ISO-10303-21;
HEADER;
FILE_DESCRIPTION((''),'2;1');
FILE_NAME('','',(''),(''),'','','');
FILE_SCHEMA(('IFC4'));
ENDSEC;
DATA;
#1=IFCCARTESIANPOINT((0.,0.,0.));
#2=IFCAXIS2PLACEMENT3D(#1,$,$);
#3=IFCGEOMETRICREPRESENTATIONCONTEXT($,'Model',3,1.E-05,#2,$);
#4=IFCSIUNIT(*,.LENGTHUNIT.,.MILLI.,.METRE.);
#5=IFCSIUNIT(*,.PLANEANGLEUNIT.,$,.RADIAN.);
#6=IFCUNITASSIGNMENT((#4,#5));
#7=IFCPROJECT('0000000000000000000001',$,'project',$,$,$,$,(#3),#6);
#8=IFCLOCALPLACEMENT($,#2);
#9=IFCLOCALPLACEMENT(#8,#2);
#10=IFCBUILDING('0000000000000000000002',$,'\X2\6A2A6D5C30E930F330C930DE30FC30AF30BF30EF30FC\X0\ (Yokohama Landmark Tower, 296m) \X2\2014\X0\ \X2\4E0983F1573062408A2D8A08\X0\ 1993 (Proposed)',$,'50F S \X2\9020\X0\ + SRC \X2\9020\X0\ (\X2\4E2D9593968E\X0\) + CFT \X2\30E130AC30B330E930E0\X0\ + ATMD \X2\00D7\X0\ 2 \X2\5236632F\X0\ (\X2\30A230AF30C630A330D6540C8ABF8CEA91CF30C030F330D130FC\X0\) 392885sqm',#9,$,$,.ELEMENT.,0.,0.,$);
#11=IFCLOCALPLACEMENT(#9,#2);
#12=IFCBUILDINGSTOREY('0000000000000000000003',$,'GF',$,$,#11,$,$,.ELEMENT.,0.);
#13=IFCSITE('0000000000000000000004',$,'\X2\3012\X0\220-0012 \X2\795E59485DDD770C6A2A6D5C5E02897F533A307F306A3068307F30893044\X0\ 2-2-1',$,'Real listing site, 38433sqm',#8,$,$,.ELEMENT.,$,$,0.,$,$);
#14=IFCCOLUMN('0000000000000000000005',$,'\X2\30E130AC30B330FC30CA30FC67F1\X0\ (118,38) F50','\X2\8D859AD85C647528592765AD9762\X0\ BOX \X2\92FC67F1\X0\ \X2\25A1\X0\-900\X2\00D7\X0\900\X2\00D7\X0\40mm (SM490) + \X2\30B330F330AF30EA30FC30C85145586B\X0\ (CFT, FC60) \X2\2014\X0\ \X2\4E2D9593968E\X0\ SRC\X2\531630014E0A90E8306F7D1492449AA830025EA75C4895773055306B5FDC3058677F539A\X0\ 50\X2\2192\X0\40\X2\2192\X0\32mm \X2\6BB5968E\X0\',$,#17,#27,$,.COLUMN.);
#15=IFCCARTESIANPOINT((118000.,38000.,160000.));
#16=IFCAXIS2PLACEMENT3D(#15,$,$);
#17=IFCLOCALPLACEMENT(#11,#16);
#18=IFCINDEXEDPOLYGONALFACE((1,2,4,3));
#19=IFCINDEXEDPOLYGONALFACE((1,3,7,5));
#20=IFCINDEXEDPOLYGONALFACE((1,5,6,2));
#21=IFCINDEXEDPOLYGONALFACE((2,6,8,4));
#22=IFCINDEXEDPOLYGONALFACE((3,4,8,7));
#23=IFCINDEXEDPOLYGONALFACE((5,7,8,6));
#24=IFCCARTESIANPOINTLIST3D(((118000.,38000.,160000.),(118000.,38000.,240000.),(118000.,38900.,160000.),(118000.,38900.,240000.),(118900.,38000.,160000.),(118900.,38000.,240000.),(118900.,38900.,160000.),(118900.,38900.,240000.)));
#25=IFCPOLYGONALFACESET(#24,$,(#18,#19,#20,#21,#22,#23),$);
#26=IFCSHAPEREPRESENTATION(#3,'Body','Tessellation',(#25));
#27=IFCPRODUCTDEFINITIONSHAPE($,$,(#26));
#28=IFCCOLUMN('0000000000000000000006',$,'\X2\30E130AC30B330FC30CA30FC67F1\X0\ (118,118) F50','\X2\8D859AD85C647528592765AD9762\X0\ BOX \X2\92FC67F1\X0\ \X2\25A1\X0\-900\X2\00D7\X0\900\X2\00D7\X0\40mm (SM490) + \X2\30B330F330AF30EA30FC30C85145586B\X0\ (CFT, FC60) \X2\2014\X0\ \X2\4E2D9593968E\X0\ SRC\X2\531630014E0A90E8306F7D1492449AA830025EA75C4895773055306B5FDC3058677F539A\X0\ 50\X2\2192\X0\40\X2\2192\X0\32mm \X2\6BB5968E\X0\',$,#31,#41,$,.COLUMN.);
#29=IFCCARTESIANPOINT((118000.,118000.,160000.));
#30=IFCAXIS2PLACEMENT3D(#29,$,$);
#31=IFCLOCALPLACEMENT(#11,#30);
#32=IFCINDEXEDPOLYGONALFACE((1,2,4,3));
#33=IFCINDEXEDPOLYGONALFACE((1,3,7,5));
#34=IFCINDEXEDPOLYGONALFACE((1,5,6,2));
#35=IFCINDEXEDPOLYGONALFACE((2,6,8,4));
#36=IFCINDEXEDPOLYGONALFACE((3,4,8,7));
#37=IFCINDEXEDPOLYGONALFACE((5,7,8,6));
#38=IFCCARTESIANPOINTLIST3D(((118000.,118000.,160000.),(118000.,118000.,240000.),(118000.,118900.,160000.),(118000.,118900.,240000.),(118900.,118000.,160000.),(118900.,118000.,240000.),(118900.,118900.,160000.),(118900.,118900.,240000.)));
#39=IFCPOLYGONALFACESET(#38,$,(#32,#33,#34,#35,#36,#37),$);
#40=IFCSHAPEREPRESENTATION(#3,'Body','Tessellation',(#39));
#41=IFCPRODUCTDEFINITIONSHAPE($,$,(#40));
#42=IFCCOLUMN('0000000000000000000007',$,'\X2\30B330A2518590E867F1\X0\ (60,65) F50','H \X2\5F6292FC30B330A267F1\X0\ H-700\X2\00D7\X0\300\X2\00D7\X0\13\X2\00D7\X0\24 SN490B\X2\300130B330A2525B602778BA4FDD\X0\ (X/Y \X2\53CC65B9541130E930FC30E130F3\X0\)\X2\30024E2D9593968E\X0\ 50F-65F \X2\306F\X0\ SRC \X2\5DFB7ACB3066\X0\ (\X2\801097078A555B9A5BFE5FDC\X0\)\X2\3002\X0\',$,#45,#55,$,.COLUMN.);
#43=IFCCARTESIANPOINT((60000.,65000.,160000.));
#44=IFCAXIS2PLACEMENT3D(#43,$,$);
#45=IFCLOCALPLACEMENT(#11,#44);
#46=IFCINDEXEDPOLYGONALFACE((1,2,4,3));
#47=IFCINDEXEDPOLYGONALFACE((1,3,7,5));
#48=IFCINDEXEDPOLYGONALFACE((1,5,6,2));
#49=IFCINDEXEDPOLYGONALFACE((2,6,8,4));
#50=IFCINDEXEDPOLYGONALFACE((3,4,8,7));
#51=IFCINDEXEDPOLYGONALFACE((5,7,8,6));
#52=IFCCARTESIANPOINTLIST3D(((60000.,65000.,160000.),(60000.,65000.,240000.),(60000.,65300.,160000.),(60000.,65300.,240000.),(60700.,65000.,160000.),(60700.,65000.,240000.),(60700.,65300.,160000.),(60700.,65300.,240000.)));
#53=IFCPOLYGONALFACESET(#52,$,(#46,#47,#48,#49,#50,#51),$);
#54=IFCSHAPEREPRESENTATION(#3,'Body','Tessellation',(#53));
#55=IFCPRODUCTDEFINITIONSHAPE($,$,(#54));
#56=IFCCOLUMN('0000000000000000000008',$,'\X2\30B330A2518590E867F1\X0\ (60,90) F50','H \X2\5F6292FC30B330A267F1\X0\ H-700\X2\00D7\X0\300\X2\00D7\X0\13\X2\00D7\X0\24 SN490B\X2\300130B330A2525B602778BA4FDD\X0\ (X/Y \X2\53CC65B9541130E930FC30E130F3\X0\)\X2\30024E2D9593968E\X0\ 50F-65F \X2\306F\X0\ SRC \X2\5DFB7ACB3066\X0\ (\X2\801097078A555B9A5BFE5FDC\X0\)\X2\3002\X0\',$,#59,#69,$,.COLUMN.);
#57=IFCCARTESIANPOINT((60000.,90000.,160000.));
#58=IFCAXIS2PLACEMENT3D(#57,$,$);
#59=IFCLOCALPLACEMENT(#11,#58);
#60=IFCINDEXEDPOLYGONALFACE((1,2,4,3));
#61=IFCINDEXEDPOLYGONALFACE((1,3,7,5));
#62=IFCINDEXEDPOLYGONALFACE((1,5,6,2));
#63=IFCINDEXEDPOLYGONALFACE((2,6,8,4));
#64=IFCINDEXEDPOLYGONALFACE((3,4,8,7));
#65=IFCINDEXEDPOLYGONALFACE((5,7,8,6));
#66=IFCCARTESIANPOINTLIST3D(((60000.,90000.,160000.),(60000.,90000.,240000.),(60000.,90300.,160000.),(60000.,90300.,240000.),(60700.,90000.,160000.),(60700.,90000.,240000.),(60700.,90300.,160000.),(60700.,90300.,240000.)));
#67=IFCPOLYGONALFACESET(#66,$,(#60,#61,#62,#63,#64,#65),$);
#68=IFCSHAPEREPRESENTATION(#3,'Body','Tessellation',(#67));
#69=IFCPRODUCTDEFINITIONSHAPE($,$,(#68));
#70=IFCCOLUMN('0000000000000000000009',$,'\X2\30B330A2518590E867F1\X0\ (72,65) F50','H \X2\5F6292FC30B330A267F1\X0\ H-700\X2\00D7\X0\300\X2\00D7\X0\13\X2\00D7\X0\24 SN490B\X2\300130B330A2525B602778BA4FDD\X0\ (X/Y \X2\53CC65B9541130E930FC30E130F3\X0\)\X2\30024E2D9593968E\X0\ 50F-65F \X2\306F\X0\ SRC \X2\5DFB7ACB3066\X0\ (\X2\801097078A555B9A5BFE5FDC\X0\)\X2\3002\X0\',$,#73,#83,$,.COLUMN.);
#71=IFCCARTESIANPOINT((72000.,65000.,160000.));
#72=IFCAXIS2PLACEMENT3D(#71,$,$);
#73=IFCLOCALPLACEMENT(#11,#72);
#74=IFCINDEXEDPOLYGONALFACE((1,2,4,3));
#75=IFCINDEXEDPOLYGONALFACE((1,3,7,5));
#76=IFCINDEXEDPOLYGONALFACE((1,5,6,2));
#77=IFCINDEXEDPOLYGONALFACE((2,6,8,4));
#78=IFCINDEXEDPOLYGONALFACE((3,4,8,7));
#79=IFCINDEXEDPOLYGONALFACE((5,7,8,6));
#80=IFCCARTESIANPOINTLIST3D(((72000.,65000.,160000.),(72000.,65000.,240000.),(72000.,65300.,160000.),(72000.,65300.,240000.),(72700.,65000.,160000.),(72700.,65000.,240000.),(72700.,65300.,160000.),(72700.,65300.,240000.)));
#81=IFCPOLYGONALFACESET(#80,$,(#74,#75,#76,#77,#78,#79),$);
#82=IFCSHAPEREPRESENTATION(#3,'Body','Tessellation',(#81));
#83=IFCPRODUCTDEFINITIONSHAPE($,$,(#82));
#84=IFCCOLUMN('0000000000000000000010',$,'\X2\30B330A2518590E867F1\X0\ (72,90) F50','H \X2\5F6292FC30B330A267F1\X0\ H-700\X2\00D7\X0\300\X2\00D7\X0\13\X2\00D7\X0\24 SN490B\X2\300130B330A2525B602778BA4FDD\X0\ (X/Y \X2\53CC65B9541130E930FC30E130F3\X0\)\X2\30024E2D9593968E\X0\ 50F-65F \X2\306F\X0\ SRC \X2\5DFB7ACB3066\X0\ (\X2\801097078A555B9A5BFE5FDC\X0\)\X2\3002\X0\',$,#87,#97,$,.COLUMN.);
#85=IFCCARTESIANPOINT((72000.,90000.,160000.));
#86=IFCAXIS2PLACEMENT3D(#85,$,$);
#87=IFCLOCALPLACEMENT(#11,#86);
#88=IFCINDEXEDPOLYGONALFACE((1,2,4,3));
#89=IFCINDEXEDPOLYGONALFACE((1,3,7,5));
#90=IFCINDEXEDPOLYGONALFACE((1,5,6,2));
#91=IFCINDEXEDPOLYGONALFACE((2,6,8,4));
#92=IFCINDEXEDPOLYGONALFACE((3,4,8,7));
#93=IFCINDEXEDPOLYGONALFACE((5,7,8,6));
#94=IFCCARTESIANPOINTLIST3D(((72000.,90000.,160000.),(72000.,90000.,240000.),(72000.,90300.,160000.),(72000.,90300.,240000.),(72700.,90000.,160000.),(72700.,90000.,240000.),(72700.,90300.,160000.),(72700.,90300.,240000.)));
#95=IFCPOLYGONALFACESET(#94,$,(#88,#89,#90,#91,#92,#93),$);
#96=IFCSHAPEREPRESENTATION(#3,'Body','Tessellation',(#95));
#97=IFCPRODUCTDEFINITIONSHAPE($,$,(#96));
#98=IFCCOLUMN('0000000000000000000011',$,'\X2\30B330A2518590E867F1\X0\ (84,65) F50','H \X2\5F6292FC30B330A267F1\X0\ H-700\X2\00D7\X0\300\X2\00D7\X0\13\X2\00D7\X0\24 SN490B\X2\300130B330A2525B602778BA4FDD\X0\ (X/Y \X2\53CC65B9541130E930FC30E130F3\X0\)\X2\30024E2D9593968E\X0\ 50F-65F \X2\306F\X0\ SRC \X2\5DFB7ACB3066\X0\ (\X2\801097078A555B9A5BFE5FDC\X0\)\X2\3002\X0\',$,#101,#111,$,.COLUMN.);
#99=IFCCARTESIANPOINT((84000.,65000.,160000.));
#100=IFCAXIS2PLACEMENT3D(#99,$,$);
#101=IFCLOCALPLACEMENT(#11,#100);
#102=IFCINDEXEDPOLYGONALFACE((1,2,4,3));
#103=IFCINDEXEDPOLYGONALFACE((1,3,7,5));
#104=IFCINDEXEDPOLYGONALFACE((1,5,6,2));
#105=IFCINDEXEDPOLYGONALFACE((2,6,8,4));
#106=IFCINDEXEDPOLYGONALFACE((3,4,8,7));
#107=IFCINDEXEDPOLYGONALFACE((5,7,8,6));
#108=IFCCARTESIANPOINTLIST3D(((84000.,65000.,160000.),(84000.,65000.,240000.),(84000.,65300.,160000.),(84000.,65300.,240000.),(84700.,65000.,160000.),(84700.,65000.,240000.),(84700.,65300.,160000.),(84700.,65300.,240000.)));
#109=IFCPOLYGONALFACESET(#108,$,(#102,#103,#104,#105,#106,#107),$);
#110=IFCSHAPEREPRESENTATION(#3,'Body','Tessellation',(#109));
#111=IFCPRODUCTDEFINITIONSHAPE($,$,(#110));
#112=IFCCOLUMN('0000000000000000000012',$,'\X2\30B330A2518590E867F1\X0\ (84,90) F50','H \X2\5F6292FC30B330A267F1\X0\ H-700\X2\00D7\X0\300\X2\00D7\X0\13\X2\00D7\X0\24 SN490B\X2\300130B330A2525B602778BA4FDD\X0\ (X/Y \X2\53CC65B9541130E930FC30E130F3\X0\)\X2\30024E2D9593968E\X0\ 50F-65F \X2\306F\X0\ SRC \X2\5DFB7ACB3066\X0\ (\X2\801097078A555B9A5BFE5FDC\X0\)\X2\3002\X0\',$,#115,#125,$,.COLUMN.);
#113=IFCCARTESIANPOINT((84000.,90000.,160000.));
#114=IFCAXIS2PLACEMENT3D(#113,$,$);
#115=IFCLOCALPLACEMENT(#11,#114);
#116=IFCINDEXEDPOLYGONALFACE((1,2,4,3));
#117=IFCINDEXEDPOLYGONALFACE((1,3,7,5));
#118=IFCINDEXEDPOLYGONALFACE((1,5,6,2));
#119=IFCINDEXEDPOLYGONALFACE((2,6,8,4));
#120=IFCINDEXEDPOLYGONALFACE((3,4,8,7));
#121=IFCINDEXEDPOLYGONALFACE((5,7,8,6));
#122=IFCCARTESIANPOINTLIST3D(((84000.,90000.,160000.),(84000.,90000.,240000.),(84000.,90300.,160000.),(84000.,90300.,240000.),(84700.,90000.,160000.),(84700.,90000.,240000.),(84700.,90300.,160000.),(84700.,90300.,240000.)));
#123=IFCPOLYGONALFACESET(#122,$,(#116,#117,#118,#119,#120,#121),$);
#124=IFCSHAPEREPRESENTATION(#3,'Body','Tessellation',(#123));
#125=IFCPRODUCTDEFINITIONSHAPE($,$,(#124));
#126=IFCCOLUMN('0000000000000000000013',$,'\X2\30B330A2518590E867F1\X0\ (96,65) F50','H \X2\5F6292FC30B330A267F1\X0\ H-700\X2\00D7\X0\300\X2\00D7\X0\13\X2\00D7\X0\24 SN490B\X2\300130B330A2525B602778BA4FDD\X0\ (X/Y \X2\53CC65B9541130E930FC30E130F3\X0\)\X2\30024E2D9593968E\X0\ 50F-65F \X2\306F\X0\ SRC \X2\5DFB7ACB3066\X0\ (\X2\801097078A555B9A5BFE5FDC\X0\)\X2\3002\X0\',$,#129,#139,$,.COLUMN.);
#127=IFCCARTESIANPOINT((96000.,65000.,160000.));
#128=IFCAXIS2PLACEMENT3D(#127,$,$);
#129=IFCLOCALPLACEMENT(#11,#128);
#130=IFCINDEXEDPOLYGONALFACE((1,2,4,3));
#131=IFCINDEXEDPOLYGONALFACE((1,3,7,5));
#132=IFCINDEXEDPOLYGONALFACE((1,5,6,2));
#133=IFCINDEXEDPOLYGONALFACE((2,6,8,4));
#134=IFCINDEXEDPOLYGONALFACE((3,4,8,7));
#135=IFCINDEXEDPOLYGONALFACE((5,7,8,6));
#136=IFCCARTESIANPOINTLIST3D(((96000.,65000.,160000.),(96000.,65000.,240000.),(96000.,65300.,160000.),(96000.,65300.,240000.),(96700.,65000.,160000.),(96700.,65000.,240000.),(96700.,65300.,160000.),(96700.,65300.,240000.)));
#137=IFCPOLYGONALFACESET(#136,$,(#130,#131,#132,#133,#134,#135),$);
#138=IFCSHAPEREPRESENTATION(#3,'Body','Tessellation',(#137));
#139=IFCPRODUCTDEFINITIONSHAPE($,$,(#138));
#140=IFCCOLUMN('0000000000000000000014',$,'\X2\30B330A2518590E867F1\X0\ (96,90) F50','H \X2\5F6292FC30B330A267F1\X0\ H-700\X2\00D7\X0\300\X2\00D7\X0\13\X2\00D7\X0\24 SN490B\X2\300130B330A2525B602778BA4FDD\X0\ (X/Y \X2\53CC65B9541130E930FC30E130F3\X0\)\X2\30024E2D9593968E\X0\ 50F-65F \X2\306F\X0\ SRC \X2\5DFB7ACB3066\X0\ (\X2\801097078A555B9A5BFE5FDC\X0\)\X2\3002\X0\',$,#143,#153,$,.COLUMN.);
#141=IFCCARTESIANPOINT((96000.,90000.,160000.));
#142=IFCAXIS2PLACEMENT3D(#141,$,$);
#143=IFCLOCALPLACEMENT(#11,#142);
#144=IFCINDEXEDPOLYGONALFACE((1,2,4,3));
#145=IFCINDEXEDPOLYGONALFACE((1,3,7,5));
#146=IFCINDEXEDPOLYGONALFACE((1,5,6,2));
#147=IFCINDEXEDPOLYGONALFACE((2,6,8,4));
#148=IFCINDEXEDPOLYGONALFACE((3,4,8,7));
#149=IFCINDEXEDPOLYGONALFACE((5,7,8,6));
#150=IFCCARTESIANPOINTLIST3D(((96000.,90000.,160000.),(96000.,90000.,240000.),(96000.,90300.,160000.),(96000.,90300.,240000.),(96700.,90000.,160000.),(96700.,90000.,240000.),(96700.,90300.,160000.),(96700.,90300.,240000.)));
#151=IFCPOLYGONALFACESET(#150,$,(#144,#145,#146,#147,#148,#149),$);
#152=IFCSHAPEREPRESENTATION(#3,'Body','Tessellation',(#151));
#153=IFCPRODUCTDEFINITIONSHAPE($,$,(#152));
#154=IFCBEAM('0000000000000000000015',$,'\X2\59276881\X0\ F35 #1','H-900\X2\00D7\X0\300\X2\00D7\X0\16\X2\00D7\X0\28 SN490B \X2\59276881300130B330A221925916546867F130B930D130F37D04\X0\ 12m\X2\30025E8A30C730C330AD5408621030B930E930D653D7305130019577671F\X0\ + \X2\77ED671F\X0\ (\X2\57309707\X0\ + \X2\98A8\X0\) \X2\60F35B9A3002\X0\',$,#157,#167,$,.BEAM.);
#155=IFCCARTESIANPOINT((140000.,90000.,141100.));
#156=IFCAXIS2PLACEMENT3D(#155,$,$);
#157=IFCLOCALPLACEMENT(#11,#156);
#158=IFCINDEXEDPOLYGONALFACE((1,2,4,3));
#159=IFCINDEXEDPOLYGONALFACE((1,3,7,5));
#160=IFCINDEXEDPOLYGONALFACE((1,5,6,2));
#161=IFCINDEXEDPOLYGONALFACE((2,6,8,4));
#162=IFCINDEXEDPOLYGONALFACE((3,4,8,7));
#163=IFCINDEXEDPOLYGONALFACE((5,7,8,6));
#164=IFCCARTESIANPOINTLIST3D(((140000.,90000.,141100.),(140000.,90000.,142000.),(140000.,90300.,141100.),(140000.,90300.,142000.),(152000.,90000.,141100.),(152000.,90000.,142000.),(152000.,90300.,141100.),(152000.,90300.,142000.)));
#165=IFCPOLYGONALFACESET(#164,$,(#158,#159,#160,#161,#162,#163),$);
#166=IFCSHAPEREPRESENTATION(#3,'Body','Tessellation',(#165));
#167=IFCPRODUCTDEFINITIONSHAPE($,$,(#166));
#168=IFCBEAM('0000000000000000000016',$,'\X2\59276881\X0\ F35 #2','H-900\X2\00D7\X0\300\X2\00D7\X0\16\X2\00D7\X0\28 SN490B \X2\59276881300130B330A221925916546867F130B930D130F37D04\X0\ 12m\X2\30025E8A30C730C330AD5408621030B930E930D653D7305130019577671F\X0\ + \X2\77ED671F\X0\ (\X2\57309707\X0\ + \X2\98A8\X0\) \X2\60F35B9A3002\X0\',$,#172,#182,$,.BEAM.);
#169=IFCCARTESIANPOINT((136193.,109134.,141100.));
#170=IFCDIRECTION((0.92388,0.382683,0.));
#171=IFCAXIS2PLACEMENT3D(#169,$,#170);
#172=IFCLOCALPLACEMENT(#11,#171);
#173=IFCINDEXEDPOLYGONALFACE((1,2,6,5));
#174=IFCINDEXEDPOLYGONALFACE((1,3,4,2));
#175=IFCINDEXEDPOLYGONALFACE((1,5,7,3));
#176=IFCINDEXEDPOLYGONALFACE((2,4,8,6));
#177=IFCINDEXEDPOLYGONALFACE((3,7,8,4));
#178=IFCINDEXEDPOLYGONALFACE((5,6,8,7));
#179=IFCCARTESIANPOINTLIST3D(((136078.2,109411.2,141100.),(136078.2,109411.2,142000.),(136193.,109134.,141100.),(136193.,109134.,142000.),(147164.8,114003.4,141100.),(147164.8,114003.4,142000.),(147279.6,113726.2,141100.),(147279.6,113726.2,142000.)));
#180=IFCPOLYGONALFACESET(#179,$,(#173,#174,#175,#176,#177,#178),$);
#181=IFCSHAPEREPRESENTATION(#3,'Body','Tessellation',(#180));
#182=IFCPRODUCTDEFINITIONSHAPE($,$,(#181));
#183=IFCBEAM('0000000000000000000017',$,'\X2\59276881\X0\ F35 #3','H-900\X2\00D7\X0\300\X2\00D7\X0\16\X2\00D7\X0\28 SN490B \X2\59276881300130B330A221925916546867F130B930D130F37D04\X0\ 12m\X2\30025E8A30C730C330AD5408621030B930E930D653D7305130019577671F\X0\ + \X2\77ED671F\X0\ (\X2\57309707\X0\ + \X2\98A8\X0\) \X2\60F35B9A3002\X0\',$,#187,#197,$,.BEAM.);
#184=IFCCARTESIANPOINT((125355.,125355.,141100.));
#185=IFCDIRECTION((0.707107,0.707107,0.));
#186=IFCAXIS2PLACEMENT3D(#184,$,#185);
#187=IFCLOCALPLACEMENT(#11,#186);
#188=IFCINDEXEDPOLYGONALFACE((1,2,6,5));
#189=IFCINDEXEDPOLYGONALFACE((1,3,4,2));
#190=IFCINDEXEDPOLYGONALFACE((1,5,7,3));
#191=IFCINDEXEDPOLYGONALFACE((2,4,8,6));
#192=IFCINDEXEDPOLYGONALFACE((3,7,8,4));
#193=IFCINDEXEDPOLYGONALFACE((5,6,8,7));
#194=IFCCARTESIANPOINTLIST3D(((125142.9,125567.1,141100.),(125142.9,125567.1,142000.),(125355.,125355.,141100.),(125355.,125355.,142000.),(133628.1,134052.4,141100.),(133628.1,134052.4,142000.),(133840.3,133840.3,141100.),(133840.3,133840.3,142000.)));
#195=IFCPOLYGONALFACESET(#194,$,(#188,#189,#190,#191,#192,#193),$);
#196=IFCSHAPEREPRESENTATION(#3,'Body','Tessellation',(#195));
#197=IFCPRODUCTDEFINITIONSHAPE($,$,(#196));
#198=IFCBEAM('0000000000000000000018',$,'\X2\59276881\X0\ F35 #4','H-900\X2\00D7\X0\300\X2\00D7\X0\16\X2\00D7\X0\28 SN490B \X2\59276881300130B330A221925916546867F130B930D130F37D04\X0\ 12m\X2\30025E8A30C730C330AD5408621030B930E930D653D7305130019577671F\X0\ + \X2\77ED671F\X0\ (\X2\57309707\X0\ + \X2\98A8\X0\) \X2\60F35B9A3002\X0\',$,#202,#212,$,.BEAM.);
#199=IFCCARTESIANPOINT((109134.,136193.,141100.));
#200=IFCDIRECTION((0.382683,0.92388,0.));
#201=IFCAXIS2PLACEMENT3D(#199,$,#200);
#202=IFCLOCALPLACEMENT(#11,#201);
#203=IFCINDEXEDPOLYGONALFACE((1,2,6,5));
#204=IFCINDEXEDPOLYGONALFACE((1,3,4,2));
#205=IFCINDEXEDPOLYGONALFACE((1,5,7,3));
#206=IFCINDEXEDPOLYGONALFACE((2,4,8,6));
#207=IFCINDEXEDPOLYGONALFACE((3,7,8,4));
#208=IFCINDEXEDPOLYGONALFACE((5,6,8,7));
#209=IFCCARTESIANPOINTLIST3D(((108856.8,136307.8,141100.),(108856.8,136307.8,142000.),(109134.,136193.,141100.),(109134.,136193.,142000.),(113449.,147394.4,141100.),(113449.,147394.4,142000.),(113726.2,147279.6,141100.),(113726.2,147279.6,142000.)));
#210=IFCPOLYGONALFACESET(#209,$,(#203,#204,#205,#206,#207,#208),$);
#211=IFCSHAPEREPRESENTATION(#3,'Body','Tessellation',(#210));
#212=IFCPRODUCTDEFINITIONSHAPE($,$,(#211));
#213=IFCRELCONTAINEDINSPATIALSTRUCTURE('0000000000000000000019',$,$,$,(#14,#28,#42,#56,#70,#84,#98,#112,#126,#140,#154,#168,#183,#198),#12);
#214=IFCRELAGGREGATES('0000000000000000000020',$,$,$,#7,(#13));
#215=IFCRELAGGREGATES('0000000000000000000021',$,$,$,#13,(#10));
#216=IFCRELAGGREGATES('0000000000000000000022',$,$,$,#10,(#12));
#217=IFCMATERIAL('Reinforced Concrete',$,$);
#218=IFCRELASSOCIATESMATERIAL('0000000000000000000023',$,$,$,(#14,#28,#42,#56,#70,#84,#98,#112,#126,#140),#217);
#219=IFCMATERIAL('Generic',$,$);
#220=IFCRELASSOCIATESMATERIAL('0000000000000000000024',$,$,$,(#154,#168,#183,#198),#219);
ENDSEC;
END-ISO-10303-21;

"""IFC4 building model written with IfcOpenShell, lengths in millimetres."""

from ifc_helpers import new_model, si_unit, frame, frame_2d, origin, place, context, project, spatial, rectangle, extrude, material, element, save


model = new_model("IFC4")

# Units and contexts
model_context = context("Model", 3, precision=1e-05, world=origin())
ifc_project = project(units=[si_unit("LENGTHUNIT", "METRE", prefix="MILLI"), si_unit("PLANEANGLEUNIT", "RADIAN")], contexts=[model_context])

# Site, building, storey
site_placement = place(None, origin())
site = spatial("IfcSite", under=ifc_project, at=site_placement, Name="〒220-0012 神奈川県横浜市西区みなとみらい 2-2-1", ObjectType="Real listing site, 38433sqm", CompositionType="ELEMENT", RefElevation=0.0)
building_placement = place(site_placement, origin())
building = spatial("IfcBuilding", under=site, at=building_placement, Name="横浜ランドマークタワー (Yokohama Landmark Tower, 296m) — 三菱地所設計 1993 (Proposed)", ObjectType="50F S 造 + SRC 造 (中間階) + CFT メガコラム + ATMD × 2 制振 (アクティブ同調質量ダンパー) 392885sqm", CompositionType="ELEMENT", ElevationOfRefHeight=0.0, ElevationOfTerrain=0.0)
storey_placement = place(building_placement, origin())
storey = spatial("IfcBuildingStorey", under=building, at=storey_placement, Name="GF", CompositionType="ELEMENT", Elevation=0.0)

# Columns
ifc_material_1 = material(Name="Reinforced Concrete")
column_1_placement = place(storey_placement, frame((118000.0, 38000.0, 160000.0)))
element("IfcColumn", 1, at=column_1_placement, inside=storey, material=ifc_material_1, Name="メガコーナー柱 (118,38) F50", Description="超高層用大断面 BOX 鋼柱 □-900×900×40mm (SM490) + コンクリート充填 (CFT, FC60) — 中間階 SRC化、上部は純鉄骨。座屈長さに応じ板厚 50→40→32mm 段階", PredefinedType="COLUMN", context=model_context, shape_type="SweptSolid", body=[
    extrude(rectangle(XDim=900.0, YDim=900.0, at=frame_2d((450.0, 450.0))), frame((118000.0, 38000.0, 160000.0)), (0.0, 0.0, 1.0), 80000.0),
])
column_2_placement = place(storey_placement, frame((118000.0, 118000.0, 160000.0)))
element("IfcColumn", 2, at=column_2_placement, inside=storey, material=ifc_material_1, Name="メガコーナー柱 (118,118) F50", Description="超高層用大断面 BOX 鋼柱 □-900×900×40mm (SM490) + コンクリート充填 (CFT, FC60) — 中間階 SRC化、上部は純鉄骨。座屈長さに応じ板厚 50→40→32mm 段階", PredefinedType="COLUMN", context=model_context, shape_type="SweptSolid", body=[
    extrude(rectangle(XDim=900.0, YDim=900.0, at=frame_2d((450.0, 450.0))), frame((118000.0, 118000.0, 160000.0)), (0.0, 0.0, 1.0), 80000.0),
])
column_3_placement = place(storey_placement, frame((60000.0, 65000.0, 160000.0)))
element("IfcColumn", 3, at=column_3_placement, inside=storey, material=ifc_material_1, Name="コア内部柱 (60,65) F50", Description="H 形鋼コア柱 H-700×300×13×24 SN490B、コア剛性確保 (X/Y 双方向ラーメン)。中間階 50F-65F は SRC 巻立て (耐震評定対応)。", PredefinedType="COLUMN", context=model_context, shape_type="SweptSolid", body=[
    extrude(rectangle(XDim=700.0, YDim=300.0, at=frame_2d((350.0, 150.0))), frame((60000.0, 65000.0, 160000.0)), (0.0, 0.0, 1.0), 80000.0),
])
column_4_placement = place(storey_placement, frame((60000.0, 90000.0, 160000.0)))
element("IfcColumn", 4, at=column_4_placement, inside=storey, material=ifc_material_1, Name="コア内部柱 (60,90) F50", Description="H 形鋼コア柱 H-700×300×13×24 SN490B、コア剛性確保 (X/Y 双方向ラーメン)。中間階 50F-65F は SRC 巻立て (耐震評定対応)。", PredefinedType="COLUMN", context=model_context, shape_type="SweptSolid", body=[
    extrude(rectangle(XDim=700.0, YDim=300.0, at=frame_2d((350.0, 150.0))), frame((60000.0, 90000.0, 160000.0)), (0.0, 0.0, 1.0), 80000.0),
])
column_5_placement = place(storey_placement, frame((72000.0, 65000.0, 160000.0)))
element("IfcColumn", 5, at=column_5_placement, inside=storey, material=ifc_material_1, Name="コア内部柱 (72,65) F50", Description="H 形鋼コア柱 H-700×300×13×24 SN490B、コア剛性確保 (X/Y 双方向ラーメン)。中間階 50F-65F は SRC 巻立て (耐震評定対応)。", PredefinedType="COLUMN", context=model_context, shape_type="SweptSolid", body=[
    extrude(rectangle(XDim=700.0, YDim=300.0, at=frame_2d((350.0, 150.0))), frame((72000.0, 65000.0, 160000.0)), (0.0, 0.0, 1.0), 80000.0),
])
column_6_placement = place(storey_placement, frame((72000.0, 90000.0, 160000.0)))
element("IfcColumn", 6, at=column_6_placement, inside=storey, material=ifc_material_1, Name="コア内部柱 (72,90) F50", Description="H 形鋼コア柱 H-700×300×13×24 SN490B、コア剛性確保 (X/Y 双方向ラーメン)。中間階 50F-65F は SRC 巻立て (耐震評定対応)。", PredefinedType="COLUMN", context=model_context, shape_type="SweptSolid", body=[
    extrude(rectangle(XDim=700.0, YDim=300.0, at=frame_2d((350.0, 150.0))), frame((72000.0, 90000.0, 160000.0)), (0.0, 0.0, 1.0), 80000.0),
])
column_7_placement = place(storey_placement, frame((84000.0, 65000.0, 160000.0)))
element("IfcColumn", 7, at=column_7_placement, inside=storey, material=ifc_material_1, Name="コア内部柱 (84,65) F50", Description="H 形鋼コア柱 H-700×300×13×24 SN490B、コア剛性確保 (X/Y 双方向ラーメン)。中間階 50F-65F は SRC 巻立て (耐震評定対応)。", PredefinedType="COLUMN", context=model_context, shape_type="SweptSolid", body=[
    extrude(rectangle(XDim=700.0, YDim=300.0, at=frame_2d((350.0, 150.0))), frame((84000.0, 65000.0, 160000.0)), (0.0, 0.0, 1.0), 80000.0),
])
column_8_placement = place(storey_placement, frame((84000.0, 90000.0, 160000.0)))
element("IfcColumn", 8, at=column_8_placement, inside=storey, material=ifc_material_1, Name="コア内部柱 (84,90) F50", Description="H 形鋼コア柱 H-700×300×13×24 SN490B、コア剛性確保 (X/Y 双方向ラーメン)。中間階 50F-65F は SRC 巻立て (耐震評定対応)。", PredefinedType="COLUMN", context=model_context, shape_type="SweptSolid", body=[
    extrude(rectangle(XDim=700.0, YDim=300.0, at=frame_2d((350.0, 150.0))), frame((84000.0, 90000.0, 160000.0)), (0.0, 0.0, 1.0), 80000.0),
])
column_9_placement = place(storey_placement, frame((96000.0, 65000.0, 160000.0)))
element("IfcColumn", 9, at=column_9_placement, inside=storey, material=ifc_material_1, Name="コア内部柱 (96,65) F50", Description="H 形鋼コア柱 H-700×300×13×24 SN490B、コア剛性確保 (X/Y 双方向ラーメン)。中間階 50F-65F は SRC 巻立て (耐震評定対応)。", PredefinedType="COLUMN", context=model_context, shape_type="SweptSolid", body=[
    extrude(rectangle(XDim=700.0, YDim=300.0, at=frame_2d((350.0, 150.0))), frame((96000.0, 65000.0, 160000.0)), (0.0, 0.0, 1.0), 80000.0),
])
column_10_placement = place(storey_placement, frame((96000.0, 90000.0, 160000.0)))
element("IfcColumn", 10, at=column_10_placement, inside=storey, material=ifc_material_1, Name="コア内部柱 (96,90) F50", Description="H 形鋼コア柱 H-700×300×13×24 SN490B、コア剛性確保 (X/Y 双方向ラーメン)。中間階 50F-65F は SRC 巻立て (耐震評定対応)。", PredefinedType="COLUMN", context=model_context, shape_type="SweptSolid", body=[
    extrude(rectangle(XDim=700.0, YDim=300.0, at=frame_2d((350.0, 150.0))), frame((96000.0, 90000.0, 160000.0)), (0.0, 0.0, 1.0), 80000.0),
])

# Beams
ifc_material_2 = material(Name="Generic")
beam_1_placement = place(storey_placement, frame((140000.0, 90000.0, 141100.0)))
element("IfcBeam", 11, at=beam_1_placement, inside=storey, material=ifc_material_2, Name="大梁 F35 #1", Description="H-900×300×16×28 SN490B 大梁、コア→外周柱スパン約 12m。床デッキ合成スラブ受け、長期 + 短期 (地震 + 風) 想定。", PredefinedType="BEAM", context=model_context, shape_type="SweptSolid", body=[
    extrude(rectangle(XDim=12000.0, YDim=300.0, at=frame_2d((6000.0, 150.0))), frame((140000.0, 90000.0, 141100.0)), (0.0, 0.0, 1.0), 900.0),
])
beam_2_placement = place(storey_placement, frame((136193.0, 109134.0, 141100.0), x_axis=(0.92388, 0.382683, 0.0)))
element("IfcBeam", 12, at=beam_2_placement, inside=storey, material=ifc_material_2, Name="大梁 F35 #2", Description="H-900×300×16×28 SN490B 大梁、コア→外周柱スパン約 12m。床デッキ合成スラブ受け、長期 + 短期 (地震 + 風) 想定。", PredefinedType="BEAM", context=model_context, shape_type="SweptSolid", body=[
    extrude(rectangle(XDim=12000.0, YDim=300.0, at=frame_2d((6000.0, 150.0))), frame((136193.0, 109134.0, 141100.0), x_axis=(0.92388, 0.382683, 0.0)), (0.0, 0.0, 1.0), 900.0),
])
beam_3_placement = place(storey_placement, frame((125355.0, 125355.0, 141100.0), x_axis=(0.707107, 0.707107, 0.0)))
element("IfcBeam", 13, at=beam_3_placement, inside=storey, material=ifc_material_2, Name="大梁 F35 #3", Description="H-900×300×16×28 SN490B 大梁、コア→外周柱スパン約 12m。床デッキ合成スラブ受け、長期 + 短期 (地震 + 風) 想定。", PredefinedType="BEAM", context=model_context, shape_type="SweptSolid", body=[
    extrude(rectangle(XDim=12000.0, YDim=300.0, at=frame_2d((6000.0, 150.0))), frame((125355.0, 125355.0, 141100.0), x_axis=(0.707107, 0.707107, 0.0)), (0.0, 0.0, 1.0), 900.0),
])
beam_4_placement = place(storey_placement, frame((109134.0, 136193.0, 141100.0), x_axis=(0.382683, 0.92388, 0.0)))
element("IfcBeam", 14, at=beam_4_placement, inside=storey, material=ifc_material_2, Name="大梁 F35 #4", Description="H-900×300×16×28 SN490B 大梁、コア→外周柱スパン約 12m。床デッキ合成スラブ受け、長期 + 短期 (地震 + 風) 想定。", PredefinedType="BEAM", context=model_context, shape_type="SweptSolid", body=[
    extrude(rectangle(XDim=12000.0, YDim=300.0, at=frame_2d((6000.0, 150.0))), frame((109134.0, 136193.0, 141100.0), x_axis=(0.382683, 0.92388, 0.0)), (0.0, 0.0, 1.0), 900.0),
])

save(model, "model.ifc")
